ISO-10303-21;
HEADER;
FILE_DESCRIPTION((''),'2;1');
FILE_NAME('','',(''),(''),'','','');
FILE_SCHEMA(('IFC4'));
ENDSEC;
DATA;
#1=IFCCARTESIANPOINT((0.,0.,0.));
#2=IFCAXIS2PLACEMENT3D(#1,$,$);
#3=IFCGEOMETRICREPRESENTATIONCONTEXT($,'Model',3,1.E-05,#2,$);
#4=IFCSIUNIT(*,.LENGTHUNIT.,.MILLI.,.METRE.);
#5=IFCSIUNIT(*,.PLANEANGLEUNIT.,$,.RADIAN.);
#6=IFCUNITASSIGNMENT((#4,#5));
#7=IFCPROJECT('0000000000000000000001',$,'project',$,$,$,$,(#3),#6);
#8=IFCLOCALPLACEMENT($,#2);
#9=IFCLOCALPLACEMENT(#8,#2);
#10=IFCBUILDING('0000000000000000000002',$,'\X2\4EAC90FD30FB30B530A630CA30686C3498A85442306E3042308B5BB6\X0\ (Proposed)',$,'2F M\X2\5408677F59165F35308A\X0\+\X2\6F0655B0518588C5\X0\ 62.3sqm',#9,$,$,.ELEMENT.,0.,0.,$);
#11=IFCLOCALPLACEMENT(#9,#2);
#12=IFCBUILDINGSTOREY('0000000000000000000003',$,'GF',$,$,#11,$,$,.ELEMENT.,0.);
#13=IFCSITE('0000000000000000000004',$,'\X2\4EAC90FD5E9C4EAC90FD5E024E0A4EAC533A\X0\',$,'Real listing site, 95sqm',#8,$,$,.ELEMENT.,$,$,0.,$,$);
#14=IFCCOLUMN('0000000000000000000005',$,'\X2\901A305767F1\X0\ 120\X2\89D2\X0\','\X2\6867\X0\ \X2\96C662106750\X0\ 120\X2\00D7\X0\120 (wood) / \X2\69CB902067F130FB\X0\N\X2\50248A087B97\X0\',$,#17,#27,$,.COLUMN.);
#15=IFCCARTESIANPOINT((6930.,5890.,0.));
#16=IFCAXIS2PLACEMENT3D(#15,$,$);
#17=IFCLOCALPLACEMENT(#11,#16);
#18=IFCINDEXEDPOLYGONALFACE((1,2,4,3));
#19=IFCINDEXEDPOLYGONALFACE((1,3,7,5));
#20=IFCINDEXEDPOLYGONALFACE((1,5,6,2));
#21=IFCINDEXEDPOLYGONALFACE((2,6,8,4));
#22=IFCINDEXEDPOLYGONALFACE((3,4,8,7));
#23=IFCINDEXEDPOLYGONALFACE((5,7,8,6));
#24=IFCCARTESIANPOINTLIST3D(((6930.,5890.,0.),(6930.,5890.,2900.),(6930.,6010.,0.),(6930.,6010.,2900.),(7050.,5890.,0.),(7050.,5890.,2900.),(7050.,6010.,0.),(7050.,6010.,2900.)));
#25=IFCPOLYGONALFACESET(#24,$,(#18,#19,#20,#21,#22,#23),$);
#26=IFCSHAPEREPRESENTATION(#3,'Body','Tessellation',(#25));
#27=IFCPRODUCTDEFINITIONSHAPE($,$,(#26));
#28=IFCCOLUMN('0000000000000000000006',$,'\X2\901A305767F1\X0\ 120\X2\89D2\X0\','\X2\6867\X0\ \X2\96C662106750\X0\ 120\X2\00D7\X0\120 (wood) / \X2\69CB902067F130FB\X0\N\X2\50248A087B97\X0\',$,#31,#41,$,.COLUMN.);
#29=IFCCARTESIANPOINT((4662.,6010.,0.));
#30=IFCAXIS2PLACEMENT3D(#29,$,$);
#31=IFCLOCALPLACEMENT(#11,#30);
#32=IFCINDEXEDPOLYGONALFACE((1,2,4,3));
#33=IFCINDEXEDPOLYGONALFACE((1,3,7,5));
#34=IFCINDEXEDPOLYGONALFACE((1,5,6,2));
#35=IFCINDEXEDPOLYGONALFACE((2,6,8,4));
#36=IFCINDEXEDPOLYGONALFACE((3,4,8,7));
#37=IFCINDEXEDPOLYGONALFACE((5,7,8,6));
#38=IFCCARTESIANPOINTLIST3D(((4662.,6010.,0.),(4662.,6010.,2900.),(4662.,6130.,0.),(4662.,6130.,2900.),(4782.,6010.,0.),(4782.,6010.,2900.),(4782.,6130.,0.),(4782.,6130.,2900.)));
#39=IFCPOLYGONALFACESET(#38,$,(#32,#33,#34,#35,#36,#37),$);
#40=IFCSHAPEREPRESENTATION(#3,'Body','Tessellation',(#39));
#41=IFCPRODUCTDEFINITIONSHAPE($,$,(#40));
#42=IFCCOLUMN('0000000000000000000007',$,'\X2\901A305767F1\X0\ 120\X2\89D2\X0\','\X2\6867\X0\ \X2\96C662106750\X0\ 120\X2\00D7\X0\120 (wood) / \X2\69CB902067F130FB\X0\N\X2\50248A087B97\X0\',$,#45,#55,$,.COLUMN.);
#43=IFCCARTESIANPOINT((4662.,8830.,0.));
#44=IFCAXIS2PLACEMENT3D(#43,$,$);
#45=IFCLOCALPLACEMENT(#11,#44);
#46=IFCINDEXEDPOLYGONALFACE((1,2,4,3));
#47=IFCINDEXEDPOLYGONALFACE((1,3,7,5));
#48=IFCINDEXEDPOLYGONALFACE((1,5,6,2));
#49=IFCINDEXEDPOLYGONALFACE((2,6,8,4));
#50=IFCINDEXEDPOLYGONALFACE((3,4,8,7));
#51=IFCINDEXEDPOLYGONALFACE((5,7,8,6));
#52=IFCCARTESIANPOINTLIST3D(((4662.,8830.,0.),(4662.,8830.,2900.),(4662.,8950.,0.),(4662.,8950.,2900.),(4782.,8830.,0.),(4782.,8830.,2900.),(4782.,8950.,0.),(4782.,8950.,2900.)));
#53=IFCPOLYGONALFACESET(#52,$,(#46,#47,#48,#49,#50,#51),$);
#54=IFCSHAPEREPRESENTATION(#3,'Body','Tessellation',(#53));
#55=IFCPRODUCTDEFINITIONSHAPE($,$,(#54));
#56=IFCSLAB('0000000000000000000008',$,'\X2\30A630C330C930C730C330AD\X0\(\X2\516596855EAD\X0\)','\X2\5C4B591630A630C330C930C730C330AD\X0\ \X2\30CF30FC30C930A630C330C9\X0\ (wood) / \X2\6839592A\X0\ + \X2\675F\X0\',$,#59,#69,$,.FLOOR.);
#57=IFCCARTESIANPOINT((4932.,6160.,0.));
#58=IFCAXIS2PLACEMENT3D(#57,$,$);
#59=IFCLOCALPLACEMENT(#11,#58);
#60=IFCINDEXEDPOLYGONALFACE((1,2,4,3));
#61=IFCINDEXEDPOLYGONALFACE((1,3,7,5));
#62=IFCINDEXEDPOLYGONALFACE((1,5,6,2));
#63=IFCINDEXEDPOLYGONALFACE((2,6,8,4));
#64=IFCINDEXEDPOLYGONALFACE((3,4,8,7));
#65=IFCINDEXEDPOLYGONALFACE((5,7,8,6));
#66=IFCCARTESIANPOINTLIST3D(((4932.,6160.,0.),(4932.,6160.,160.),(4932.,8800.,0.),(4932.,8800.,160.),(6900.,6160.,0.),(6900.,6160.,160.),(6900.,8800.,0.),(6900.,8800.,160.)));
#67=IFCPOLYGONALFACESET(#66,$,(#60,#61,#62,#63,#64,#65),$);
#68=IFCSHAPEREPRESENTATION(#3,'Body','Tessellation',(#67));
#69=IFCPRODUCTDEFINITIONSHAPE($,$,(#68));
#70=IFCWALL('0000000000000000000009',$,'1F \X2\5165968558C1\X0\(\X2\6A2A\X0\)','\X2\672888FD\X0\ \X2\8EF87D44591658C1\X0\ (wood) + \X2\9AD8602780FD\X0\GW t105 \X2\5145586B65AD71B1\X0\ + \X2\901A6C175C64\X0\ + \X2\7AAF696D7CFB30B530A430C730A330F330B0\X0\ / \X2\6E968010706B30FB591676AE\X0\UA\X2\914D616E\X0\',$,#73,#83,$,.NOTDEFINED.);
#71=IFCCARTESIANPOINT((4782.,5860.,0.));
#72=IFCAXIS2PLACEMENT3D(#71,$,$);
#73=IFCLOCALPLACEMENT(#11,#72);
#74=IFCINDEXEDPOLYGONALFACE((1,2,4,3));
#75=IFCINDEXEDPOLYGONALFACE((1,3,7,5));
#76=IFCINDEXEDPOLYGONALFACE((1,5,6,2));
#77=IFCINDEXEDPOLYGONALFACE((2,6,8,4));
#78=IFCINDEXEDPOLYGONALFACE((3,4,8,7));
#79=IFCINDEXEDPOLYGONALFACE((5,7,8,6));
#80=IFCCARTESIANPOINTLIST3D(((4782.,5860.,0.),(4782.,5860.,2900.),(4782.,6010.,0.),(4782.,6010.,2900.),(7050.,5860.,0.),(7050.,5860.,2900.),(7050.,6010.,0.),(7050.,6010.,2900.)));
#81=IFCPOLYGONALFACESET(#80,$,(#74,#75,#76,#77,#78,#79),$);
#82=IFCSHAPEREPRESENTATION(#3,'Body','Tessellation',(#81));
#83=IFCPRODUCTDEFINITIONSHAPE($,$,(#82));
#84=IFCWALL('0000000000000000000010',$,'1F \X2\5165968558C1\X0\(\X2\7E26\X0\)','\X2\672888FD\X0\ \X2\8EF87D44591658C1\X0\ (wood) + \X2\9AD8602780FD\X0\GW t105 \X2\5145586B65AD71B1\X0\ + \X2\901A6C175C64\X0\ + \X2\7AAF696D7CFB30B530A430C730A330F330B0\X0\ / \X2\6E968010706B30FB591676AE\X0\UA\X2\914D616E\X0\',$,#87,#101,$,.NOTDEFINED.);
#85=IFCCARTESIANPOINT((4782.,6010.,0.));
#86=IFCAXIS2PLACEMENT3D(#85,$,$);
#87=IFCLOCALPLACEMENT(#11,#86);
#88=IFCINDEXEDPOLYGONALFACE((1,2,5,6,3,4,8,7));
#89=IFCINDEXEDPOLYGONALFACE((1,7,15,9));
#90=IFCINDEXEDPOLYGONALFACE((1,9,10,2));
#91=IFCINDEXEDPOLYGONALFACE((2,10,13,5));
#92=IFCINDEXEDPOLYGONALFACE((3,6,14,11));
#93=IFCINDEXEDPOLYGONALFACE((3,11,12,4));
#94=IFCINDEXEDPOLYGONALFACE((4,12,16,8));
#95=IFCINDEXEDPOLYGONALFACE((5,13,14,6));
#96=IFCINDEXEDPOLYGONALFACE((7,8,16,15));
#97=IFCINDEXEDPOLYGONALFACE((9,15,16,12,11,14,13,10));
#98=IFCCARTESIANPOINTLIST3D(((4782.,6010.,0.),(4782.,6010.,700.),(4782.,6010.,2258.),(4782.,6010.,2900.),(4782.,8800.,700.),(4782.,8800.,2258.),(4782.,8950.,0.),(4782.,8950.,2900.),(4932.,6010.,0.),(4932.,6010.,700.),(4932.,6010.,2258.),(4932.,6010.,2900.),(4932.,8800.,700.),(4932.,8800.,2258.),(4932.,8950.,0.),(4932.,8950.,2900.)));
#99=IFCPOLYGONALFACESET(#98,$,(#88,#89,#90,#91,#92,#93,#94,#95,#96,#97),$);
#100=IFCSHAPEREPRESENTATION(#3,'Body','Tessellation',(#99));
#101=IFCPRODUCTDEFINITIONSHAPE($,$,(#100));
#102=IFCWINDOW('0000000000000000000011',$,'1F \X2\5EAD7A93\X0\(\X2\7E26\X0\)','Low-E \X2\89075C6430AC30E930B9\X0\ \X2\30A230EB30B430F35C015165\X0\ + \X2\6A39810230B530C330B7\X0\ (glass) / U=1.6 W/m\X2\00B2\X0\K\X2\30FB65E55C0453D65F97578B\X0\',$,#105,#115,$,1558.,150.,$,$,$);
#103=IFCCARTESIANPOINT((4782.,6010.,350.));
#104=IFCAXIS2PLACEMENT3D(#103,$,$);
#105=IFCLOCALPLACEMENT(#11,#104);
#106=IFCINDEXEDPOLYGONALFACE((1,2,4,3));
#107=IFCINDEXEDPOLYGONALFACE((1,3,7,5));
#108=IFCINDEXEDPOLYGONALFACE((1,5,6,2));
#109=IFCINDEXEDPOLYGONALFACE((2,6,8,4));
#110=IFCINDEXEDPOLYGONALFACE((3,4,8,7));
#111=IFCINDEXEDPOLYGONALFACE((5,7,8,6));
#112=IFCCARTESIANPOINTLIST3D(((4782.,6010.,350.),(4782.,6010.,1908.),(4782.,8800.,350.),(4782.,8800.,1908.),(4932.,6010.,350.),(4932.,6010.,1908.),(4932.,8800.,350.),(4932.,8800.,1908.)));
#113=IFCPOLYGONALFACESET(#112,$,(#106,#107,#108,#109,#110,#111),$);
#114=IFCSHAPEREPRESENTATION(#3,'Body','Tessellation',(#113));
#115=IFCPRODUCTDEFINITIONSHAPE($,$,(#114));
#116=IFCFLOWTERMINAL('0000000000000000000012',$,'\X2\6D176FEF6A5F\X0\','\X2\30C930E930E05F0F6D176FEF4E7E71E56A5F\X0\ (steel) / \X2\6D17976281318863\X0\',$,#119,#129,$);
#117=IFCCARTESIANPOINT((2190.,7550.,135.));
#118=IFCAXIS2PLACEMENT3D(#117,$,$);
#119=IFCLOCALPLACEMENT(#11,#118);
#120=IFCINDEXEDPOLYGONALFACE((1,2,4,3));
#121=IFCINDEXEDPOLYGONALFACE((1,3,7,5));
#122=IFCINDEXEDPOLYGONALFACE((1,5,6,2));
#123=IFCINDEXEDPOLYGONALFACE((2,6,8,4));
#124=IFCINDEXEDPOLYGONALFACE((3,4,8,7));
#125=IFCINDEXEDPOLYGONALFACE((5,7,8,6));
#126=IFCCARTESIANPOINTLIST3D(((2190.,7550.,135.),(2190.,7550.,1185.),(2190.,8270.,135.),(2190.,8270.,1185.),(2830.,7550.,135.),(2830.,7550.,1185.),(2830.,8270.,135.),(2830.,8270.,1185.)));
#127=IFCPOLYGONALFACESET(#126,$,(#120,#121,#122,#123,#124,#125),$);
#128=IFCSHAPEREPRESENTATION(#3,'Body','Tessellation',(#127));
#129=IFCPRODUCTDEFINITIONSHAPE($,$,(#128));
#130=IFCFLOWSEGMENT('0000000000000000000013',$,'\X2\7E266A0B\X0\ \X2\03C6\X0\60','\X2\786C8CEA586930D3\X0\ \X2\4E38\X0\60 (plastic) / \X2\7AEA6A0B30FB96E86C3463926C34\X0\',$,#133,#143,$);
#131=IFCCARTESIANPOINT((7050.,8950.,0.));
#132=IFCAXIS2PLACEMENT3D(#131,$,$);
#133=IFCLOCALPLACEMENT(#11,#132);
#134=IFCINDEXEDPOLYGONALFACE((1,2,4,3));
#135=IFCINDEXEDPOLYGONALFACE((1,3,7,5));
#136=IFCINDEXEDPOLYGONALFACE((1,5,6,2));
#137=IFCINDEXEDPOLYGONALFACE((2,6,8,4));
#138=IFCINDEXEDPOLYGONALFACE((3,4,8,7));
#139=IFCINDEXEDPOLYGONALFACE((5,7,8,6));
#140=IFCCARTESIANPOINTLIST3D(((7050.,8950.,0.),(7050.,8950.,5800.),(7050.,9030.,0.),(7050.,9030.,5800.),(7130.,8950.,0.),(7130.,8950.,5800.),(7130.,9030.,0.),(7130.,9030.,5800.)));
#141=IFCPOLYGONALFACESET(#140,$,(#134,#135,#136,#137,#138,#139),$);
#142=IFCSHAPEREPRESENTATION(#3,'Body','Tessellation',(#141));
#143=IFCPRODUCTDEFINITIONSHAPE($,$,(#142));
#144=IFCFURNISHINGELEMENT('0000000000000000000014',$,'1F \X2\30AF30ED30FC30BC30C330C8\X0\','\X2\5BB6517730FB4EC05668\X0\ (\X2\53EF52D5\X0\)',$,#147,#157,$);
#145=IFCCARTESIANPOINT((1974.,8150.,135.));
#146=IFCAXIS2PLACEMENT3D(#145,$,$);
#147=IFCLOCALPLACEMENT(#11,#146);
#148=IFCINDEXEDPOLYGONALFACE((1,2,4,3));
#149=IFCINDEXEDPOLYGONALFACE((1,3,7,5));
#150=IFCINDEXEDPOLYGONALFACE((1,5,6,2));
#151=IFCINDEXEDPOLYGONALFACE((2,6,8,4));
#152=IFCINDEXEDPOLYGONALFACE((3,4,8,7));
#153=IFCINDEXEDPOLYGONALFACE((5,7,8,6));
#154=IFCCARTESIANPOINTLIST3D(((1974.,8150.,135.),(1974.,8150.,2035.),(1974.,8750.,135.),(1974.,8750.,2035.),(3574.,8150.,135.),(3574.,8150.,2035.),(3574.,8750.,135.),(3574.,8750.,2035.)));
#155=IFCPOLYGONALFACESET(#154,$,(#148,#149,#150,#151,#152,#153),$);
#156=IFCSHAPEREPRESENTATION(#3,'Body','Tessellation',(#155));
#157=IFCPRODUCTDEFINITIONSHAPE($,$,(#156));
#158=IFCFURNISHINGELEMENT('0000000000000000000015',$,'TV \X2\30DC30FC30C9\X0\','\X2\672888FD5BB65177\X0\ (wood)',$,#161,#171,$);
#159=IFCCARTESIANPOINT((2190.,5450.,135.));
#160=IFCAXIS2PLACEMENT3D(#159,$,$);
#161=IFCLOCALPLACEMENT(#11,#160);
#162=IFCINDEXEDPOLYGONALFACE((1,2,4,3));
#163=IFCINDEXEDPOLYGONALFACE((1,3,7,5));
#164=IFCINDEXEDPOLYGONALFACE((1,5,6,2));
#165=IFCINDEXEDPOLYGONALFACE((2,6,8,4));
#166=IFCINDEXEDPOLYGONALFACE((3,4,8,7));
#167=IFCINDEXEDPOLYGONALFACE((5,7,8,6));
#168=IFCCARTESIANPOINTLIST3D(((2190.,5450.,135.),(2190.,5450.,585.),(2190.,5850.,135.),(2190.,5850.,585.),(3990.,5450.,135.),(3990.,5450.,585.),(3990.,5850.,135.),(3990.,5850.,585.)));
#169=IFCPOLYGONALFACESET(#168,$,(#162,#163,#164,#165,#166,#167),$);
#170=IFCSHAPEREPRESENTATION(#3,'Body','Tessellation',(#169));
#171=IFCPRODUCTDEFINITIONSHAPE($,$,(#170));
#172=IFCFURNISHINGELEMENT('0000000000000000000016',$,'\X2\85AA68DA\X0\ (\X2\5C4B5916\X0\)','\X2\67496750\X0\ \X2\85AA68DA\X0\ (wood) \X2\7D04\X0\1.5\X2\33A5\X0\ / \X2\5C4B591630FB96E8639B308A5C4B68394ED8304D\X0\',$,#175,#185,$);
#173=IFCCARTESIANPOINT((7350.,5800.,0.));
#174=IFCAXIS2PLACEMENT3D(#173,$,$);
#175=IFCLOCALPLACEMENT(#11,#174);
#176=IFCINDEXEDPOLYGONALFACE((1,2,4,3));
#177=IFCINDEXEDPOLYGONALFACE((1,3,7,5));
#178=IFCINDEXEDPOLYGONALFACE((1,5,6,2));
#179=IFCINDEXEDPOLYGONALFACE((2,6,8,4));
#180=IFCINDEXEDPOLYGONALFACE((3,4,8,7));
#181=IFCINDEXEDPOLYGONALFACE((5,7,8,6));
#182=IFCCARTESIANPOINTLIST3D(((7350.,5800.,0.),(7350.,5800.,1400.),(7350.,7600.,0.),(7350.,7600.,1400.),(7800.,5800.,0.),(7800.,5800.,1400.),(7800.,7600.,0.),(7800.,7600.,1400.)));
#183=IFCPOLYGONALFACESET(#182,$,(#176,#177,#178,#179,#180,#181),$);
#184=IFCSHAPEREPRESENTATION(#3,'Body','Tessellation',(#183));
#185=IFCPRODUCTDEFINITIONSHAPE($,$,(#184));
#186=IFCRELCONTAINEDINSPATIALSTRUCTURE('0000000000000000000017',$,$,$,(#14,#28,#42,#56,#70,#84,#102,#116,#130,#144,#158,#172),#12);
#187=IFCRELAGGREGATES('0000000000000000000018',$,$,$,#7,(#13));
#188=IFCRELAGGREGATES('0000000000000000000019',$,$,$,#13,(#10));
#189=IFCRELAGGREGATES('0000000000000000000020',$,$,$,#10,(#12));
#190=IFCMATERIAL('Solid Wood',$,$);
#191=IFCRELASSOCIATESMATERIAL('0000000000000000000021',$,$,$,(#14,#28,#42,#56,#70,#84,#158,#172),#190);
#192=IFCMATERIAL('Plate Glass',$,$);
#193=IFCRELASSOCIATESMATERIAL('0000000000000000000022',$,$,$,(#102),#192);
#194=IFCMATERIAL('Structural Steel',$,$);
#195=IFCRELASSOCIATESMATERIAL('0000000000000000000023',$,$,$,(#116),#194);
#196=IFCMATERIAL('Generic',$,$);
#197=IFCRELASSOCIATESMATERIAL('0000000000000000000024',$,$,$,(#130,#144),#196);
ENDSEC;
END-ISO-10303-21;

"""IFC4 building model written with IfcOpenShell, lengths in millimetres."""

from ifc_helpers import new_model, si_unit, frame, frame_2d, origin, place, context, project, spatial, rectangle, extrude, material, element, fill, save


model = new_model("IFC4")

# Units and contexts
model_context = context("Model", 3, precision=1e-05, world=origin())
ifc_project = project(units=[si_unit("LENGTHUNIT", "METRE", prefix="MILLI"), si_unit("PLANEANGLEUNIT", "RADIAN")], contexts=[model_context])

# Site, building, storey
site_placement = place(None, origin())
site = spatial("IfcSite", under=ifc_project, at=site_placement, Name="京都府京都市上京区", ObjectType="Real listing site, 95sqm", CompositionType="ELEMENT", RefElevation=0.0)
building_placement = place(site_placement, origin())
building = spatial("IfcBuilding", under=site, at=building_placement, Name="京都・サウナと水風呂のある家 (Proposed)", ObjectType="2F M合板外張り+漆喰内装 62.3sqm", CompositionType="ELEMENT", ElevationOfRefHeight=0.0, ElevationOfTerrain=0.0)
storey_placement = place(building_placement, origin())
storey = spatial("IfcBuildingStorey", under=building, at=storey_placement, Name="GF", CompositionType="ELEMENT", Elevation=0.0)

# Columns
ifc_material_1 = material(Name="Solid Wood")
column_1_placement = place(storey_placement, frame((6930.0, 5890.0, 0.0)))
element("IfcColumn", 1, at=column_1_placement, inside=storey, material=ifc_material_1, Name="通し柱 120角", Description="桧 集成材 120×120 (wood) / 構造柱・N値計算", PredefinedType="COLUMN", context=model_context, shape_type="SweptSolid", body=[
    extrude(rectangle(XDim=120.0, YDim=120.0, at=frame_2d((60.0, 60.0))), frame((6930.0, 5890.0, 0.0)), (0.0, 0.0, 1.0), 2900.0),
])
column_2_placement = place(storey_placement, frame((4662.0, 6010.0, 0.0)))
element("IfcColumn", 2, at=column_2_placement, inside=storey, material=ifc_material_1, Name="通し柱 120角", Description="桧 集成材 120×120 (wood) / 構造柱・N値計算", PredefinedType="COLUMN", context=model_context, shape_type="SweptSolid", body=[
    extrude(rectangle(XDim=120.0, YDim=120.0, at=frame_2d((60.0, 60.0))), frame((4662.0, 6010.0, 0.0)), (0.0, 0.0, 1.0), 2900.0),
])
column_3_placement = place(storey_placement, frame((4662.0, 8830.0, 0.0)))
element("IfcColumn", 3, at=column_3_placement, inside=storey, material=ifc_material_1, Name="通し柱 120角", Description="桧 集成材 120×120 (wood) / 構造柱・N値計算", PredefinedType="COLUMN", context=model_context, shape_type="SweptSolid", body=[
    extrude(rectangle(XDim=120.0, YDim=120.0, at=frame_2d((60.0, 60.0))), frame((4662.0, 8830.0, 0.0)), (0.0, 0.0, 1.0), 2900.0),
])

# Slab
slab_placement = place(storey_placement, frame((4932.0, 6160.0, 0.0)))
element("IfcSlab", 4, at=slab_placement, inside=storey, material=ifc_material_1, Name="ウッドデッキ(入隅庭)", Description="屋外ウッドデッキ ハードウッド (wood) / 根太 + 束", PredefinedType="FLOOR", context=model_context, shape_type="SweptSolid", body=[
    extrude(rectangle(XDim=1968.0, YDim=2640.0, at=frame_2d((984.0, 1320.0))), frame((4932.0, 6160.0, 0.0)), (0.0, 0.0, 1.0), 160.0),
])

# Wall
wall_1_placement = place(storey_placement, frame((4782.0, 5860.0, 0.0)))
element("IfcWall", 5, at=wall_1_placement, inside=storey, material=ifc_material_1, Name="1F 入隅壁(横)", Description="木製 軸組外壁 (wood) + 高性能GW t105 充填断熱 + 通気層 + 窯業系サイディング / 準耐火・外皮UA配慮", PredefinedType="NOTDEFINED", context=model_context, shape_type="SweptSolid", body=[
    extrude(rectangle(XDim=2268.0, YDim=150.0, at=frame_2d((1134.0, 75.0))), frame((4782.0, 5860.0, 0.0)), (0.0, 0.0, 1.0), 2900.0),
])

# Wall, opening, window
wall_2_placement = place(storey_placement, frame((4782.0, 6010.0, 0.0)))
wall_2 = element("IfcWall", 6, at=wall_2_placement, inside=storey, material=ifc_material_1, Name="1F 入隅壁(縦)", Description="木製 軸組外壁 (wood) + 高性能GW t105 充填断熱 + 通気層 + 窯業系サイディング / 準耐火・外皮UA配慮", PredefinedType="NOTDEFINED", context=model_context, shape_type="SweptSolid", body=[
    extrude(rectangle(XDim=150.0, YDim=2940.0, at=frame_2d((75.0, 1470.0))), frame((4782.0, 6010.0, 0.0)), (0.0, 0.0, 1.0), 2900.0),
])
opening_placement = place(storey_placement, frame((4782.0, 6010.0, 350.0)))
opening = element("IfcOpeningElement", 7, at=opening_placement, cuts=wall_2, PredefinedType="NOTDEFINED", context=model_context, shape_type="SweptSolid", body=[
    extrude(rectangle(XDim=150.0, YDim=2790.0, at=frame_2d((75.0, 1395.0))), frame((4782.0, 6010.0, 350.0)), (0.0, 0.0, 1.0), 1558.0),
])
ifc_material_2 = material(Name="Plate Glass")
window_placement = place(storey_placement, frame((4782.0, 6010.0, 350.0)))
window = element("IfcWindow", 8, at=window_placement, inside=storey, material=ifc_material_2, Name="1F 庭窓(縦)", Description="Low-E 複層ガラス アルゴン封入 + 樹脂サッシ (glass) / U=1.6 W/m²K・日射取得型", OverallHeight=1558.0, OverallWidth=150.0, context=model_context, shape_type="SweptSolid", body=[
    extrude(rectangle(XDim=150.0, YDim=2790.0, at=frame_2d((75.0, 1395.0))), frame((4782.0, 6010.0, 350.0)), (0.0, 0.0, 1.0), 1558.0),
])
fill(opening, window)

# Flow terminal
ifc_material_3 = material(Name="Structural Steel")
flow_terminal_placement = place(storey_placement, frame((2190.0, 7550.0, 135.0)))
element("IfcFlowTerminal", 9, at=flow_terminal_placement, inside=storey, material=ifc_material_3, Name="洗濯機", Description="ドラム式洗濯乾燥機 (steel) / 洗面脱衣", context=model_context, shape_type="SweptSolid", body=[
    extrude(rectangle(XDim=640.0, YDim=720.0, at=frame_2d((320.0, 360.0))), frame((2190.0, 7550.0, 135.0)), (0.0, 0.0, 1.0), 1050.0),
])

# Flow segment
ifc_material_4 = material(Name="Generic")
flow_segment_placement = place(storey_placement, frame((7050.0, 8950.0, 0.0)))
element("IfcFlowSegment", 10, at=flow_segment_placement, inside=storey, material=ifc_material_4, Name="縦樋 φ60", Description="硬質塩ビ 丸60 (plastic) / 竪樋・雨水排水", context=model_context, shape_type="SweptSolid", body=[
    extrude(rectangle(XDim=80.0, YDim=80.0, at=frame_2d((40.0, 40.0))), frame((7050.0, 8950.0, 0.0)), (0.0, 0.0, 1.0), 5800.0),
])

# Furnishing elements
furnishing_1_placement = place(storey_placement, frame((1974.0, 8150.0, 135.0)))
element("IfcFurnishingElement", 11, at=furnishing_1_placement, inside=storey, material=ifc_material_4, Name="1F クローゼット", Description="家具・什器 (可動)", context=model_context, shape_type="SweptSolid", body=[
    extrude(rectangle(XDim=1600.0, YDim=600.0, at=frame_2d((800.0, 300.0))), frame((1974.0, 8150.0, 135.0)), (0.0, 0.0, 1.0), 1900.0),
])
furnishing_2_placement = place(storey_placement, frame((2190.0, 5450.0, 135.0)))
element("IfcFurnishingElement", 12, at=furnishing_2_placement, inside=storey, material=ifc_material_1, Name="TV ボード", Description="木製家具 (wood)", context=model_context, shape_type="SweptSolid", body=[
    extrude(rectangle(XDim=1800.0, YDim=400.0, at=frame_2d((900.0, 200.0))), frame((2190.0, 5450.0, 135.0)), (0.0, 0.0, 1.0), 450.0),
])
furnishing_3_placement = place(storey_placement, frame((7350.0, 5800.0, 0.0)))
element("IfcFurnishingElement", 13, at=furnishing_3_placement, inside=storey, material=ifc_material_1, Name="薪棚 (屋外)", Description="杉材 薪棚 (wood) 約1.5㎥ / 屋外・雨掛り屋根付き", context=model_context, shape_type="SweptSolid", body=[
    extrude(rectangle(XDim=450.0, YDim=1800.0, at=frame_2d((225.0, 900.0))), frame((7350.0, 5800.0, 0.0)), (0.0, 0.0, 1.0), 1400.0),
])

save(model, "model.ifc")
